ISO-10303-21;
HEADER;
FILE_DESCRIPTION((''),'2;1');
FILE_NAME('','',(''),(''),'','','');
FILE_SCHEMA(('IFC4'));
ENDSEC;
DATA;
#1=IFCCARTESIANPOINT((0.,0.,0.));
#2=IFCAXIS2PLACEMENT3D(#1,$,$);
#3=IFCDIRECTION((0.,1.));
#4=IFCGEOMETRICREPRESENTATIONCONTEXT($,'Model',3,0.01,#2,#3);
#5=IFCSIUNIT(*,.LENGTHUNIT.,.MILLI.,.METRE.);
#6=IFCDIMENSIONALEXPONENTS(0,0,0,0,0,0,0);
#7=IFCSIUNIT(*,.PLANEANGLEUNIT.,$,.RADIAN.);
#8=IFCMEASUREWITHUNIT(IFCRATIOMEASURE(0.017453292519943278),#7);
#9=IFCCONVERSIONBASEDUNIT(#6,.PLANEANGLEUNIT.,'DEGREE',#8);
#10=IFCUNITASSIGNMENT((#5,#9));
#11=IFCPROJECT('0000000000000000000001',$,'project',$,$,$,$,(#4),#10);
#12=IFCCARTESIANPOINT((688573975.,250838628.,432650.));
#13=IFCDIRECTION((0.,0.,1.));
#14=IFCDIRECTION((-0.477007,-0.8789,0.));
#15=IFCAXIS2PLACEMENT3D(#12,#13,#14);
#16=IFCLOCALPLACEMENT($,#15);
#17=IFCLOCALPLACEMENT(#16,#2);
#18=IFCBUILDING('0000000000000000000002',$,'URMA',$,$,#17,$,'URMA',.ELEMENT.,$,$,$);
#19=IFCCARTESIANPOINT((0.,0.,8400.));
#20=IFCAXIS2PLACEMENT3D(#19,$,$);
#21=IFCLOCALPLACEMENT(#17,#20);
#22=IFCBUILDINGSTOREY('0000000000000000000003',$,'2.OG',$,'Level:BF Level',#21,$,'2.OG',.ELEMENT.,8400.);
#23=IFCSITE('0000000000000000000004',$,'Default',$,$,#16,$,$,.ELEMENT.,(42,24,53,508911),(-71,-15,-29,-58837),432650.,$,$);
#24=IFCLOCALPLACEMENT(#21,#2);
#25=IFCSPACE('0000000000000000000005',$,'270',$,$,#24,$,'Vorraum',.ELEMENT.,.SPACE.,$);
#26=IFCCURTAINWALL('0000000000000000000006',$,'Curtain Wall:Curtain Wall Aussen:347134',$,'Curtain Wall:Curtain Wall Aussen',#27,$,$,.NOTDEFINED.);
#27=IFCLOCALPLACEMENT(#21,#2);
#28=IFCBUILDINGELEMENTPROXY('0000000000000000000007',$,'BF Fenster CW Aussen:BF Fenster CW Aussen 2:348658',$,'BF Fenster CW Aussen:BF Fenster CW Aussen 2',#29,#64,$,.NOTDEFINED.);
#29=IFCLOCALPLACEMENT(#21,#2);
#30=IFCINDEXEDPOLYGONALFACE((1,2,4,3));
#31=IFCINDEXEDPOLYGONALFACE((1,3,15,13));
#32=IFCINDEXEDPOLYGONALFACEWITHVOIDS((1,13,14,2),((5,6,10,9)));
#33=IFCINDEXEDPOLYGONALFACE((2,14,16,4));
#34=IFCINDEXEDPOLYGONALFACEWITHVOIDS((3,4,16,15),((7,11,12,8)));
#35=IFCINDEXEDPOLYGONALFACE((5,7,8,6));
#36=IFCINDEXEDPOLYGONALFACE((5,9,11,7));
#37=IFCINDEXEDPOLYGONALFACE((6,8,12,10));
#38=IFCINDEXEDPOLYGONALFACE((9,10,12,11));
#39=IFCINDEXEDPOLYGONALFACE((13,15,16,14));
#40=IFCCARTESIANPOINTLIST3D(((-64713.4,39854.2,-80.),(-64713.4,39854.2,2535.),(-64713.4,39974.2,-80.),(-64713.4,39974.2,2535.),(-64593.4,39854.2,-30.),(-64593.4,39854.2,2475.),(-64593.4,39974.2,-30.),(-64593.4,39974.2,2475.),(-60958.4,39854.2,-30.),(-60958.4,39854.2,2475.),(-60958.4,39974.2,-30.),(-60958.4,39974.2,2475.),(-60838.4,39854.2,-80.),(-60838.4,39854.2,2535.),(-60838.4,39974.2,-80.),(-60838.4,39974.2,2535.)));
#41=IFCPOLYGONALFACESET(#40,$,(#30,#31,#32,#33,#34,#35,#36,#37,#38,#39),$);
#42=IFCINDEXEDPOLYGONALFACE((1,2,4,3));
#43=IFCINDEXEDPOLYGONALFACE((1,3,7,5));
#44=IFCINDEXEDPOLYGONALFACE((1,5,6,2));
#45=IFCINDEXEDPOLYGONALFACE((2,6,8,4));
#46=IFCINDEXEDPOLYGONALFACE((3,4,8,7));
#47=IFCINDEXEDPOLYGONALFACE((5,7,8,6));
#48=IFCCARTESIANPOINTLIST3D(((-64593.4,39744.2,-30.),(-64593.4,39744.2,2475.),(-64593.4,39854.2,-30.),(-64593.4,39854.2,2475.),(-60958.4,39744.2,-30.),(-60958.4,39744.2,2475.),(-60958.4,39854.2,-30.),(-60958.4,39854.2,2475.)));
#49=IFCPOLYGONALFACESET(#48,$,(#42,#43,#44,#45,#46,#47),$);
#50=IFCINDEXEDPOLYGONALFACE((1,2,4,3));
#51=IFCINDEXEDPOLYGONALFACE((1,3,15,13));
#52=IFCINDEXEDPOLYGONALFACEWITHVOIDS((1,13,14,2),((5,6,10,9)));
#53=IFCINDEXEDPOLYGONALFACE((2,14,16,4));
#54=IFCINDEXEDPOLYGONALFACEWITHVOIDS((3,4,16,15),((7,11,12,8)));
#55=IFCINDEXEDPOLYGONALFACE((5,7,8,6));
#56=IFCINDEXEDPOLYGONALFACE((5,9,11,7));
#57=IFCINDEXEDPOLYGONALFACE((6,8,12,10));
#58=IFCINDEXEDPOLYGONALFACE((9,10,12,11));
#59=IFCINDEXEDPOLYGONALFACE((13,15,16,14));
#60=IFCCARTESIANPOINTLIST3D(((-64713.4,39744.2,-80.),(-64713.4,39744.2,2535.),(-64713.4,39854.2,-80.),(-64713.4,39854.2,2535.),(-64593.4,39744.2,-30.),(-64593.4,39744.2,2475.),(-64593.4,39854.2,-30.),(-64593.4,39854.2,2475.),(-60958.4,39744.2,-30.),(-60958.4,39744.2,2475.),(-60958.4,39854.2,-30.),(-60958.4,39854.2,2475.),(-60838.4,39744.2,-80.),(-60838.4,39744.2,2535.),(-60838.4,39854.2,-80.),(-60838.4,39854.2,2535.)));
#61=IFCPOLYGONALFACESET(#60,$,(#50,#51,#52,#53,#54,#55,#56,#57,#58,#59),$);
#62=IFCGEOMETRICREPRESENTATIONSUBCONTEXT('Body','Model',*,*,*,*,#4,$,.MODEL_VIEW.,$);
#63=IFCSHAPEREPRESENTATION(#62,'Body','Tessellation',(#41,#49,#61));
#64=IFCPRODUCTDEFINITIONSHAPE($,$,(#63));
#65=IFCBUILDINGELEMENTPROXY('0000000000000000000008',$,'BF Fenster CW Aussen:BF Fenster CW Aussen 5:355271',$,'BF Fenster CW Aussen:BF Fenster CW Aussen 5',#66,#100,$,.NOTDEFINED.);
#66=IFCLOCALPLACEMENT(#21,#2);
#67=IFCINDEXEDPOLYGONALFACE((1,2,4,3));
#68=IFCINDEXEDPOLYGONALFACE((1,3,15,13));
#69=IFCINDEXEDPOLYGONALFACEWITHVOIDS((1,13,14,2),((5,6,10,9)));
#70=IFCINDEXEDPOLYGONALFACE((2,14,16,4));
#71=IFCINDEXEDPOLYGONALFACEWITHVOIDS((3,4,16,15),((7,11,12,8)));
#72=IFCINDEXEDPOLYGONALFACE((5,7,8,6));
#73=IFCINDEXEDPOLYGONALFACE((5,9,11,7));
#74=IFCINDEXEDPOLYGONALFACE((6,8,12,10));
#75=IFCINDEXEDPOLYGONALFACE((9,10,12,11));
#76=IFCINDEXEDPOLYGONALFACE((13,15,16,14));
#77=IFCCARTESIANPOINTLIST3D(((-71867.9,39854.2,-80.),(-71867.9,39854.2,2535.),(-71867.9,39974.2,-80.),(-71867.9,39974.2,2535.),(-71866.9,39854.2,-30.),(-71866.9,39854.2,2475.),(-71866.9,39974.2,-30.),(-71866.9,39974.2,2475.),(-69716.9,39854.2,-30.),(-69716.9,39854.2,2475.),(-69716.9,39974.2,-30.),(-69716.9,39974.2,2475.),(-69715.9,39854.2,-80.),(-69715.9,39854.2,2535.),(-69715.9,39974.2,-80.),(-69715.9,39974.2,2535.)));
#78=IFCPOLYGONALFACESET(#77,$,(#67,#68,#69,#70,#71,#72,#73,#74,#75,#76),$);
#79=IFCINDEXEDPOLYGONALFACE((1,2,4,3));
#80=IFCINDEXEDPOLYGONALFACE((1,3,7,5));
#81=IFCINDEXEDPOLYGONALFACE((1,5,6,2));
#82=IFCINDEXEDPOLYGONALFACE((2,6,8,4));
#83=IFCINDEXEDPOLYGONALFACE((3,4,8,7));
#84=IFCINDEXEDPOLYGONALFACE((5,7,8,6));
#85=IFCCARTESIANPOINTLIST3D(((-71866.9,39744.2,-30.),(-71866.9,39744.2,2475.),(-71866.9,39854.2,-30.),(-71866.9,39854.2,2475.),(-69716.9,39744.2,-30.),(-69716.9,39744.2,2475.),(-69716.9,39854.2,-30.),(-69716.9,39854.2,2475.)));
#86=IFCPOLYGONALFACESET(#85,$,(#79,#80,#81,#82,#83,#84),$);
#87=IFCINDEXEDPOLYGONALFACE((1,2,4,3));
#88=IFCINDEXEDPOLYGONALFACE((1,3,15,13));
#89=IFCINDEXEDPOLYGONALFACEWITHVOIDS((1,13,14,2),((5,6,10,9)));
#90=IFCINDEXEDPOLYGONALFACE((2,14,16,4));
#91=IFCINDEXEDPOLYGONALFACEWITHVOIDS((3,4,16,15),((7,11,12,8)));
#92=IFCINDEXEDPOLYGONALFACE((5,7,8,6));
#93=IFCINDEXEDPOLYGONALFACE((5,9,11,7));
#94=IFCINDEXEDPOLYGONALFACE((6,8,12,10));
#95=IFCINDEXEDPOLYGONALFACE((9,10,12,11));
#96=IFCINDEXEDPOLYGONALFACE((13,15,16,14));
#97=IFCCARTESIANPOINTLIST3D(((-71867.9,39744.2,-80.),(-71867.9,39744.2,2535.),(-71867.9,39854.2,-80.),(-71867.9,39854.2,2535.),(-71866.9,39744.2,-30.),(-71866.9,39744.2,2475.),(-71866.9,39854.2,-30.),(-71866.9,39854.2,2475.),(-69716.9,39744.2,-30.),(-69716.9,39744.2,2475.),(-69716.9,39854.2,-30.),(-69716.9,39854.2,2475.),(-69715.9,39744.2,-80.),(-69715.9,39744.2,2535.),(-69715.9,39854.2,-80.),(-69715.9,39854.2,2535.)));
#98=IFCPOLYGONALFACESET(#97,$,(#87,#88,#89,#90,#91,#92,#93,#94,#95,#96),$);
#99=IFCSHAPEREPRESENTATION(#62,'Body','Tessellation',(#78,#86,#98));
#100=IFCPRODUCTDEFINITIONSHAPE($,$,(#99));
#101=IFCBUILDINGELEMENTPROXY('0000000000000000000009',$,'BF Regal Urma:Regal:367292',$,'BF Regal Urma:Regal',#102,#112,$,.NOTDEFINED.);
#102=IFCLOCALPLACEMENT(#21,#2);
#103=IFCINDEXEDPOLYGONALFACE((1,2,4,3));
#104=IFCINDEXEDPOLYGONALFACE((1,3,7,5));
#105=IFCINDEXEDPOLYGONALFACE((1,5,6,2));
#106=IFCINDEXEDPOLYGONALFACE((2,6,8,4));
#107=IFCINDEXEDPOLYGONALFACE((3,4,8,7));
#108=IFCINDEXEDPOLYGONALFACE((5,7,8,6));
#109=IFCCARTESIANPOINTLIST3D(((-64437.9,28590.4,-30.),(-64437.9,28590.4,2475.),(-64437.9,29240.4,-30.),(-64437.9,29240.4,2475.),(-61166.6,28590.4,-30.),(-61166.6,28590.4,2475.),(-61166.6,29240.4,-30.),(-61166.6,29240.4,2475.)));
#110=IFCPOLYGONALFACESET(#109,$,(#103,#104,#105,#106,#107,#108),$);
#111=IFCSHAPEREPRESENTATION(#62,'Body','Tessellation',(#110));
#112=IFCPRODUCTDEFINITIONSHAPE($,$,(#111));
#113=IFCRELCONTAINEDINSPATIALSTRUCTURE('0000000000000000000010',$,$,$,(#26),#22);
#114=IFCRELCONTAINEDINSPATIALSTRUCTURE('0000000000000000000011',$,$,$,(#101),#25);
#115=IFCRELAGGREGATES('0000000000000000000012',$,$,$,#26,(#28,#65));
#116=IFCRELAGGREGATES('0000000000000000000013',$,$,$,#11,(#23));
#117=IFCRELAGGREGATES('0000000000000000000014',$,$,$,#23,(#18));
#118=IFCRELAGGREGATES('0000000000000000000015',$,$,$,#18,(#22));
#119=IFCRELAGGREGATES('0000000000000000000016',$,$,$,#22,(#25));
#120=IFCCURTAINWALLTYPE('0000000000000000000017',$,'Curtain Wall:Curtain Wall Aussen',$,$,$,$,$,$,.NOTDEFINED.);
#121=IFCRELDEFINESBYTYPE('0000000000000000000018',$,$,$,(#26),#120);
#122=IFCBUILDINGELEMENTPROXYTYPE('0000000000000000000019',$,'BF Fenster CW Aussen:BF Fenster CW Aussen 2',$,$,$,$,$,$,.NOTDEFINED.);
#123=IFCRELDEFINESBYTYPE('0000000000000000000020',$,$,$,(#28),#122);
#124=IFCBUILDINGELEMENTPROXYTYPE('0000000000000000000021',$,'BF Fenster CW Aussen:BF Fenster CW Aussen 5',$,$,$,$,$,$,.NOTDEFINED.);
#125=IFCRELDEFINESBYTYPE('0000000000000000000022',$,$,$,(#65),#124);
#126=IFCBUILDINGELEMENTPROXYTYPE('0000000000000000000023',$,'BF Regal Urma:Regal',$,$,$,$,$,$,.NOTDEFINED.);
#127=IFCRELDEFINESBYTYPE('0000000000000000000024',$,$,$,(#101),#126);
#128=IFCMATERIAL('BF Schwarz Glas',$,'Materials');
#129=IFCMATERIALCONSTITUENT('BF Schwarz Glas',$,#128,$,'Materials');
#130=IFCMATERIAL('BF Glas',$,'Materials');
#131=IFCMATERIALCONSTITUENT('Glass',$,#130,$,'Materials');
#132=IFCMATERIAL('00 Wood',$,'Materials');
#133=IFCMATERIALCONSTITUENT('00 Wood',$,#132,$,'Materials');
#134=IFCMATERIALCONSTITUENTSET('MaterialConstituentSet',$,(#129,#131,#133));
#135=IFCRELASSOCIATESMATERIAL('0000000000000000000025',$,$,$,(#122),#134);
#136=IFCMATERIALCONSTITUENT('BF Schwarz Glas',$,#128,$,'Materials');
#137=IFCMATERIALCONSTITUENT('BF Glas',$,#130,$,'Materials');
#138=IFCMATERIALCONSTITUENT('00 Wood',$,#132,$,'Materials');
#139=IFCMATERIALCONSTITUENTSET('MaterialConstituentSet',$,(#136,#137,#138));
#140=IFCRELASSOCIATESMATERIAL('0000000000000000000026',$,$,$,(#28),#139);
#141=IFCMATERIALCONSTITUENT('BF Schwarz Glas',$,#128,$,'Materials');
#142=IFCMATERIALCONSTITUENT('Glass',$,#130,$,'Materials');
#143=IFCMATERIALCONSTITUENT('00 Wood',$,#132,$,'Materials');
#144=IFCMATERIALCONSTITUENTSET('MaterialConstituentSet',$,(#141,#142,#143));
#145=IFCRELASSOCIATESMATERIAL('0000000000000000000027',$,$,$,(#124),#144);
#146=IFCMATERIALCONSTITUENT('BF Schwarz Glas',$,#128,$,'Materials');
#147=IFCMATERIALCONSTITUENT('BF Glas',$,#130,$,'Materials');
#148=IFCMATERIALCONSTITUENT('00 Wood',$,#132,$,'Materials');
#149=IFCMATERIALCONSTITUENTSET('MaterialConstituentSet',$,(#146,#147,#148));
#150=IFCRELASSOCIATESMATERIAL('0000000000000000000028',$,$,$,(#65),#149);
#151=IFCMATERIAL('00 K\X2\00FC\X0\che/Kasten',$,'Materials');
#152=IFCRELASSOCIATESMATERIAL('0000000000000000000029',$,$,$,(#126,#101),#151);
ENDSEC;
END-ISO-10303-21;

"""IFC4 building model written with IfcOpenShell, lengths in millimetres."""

from ifc_helpers import new_model, entity, si_unit, converted_unit, direction, frame, origin, place, context, subcontext, project, spatial, indexed_curve, outline, extrude, source, transform, mapped, material, constituent, constituent_set, type_object, type_shapes, element, aggregate, save


model = new_model("IFC4")

# Units and contexts
model_context = context("Model", 3, precision=0.01, world=origin(), true_north=direction((0.0, 1.0)))
body_context = subcontext(model_context, "Body", "Model", "MODEL_VIEW")
ifc_project = project(units=[si_unit("LENGTHUNIT", "METRE", prefix="MILLI"), converted_unit("PLANEANGLEUNIT", "DEGREE", entity("IfcRatioMeasure", 0.017453292519943278), si_unit("PLANEANGLEUNIT", "RADIAN"), dimensions=[0, 0, 0, 0, 0, 0, 0])], contexts=[model_context])

# Site, building, storey
site_placement = place(None, frame((688573975.0, 250838628.0, 432650.0), z_axis=(0.0, 0.0, 1.0), x_axis=(-0.477007, -0.8789, 0.0)))
site = spatial("IfcSite", under=ifc_project, at=site_placement, Name="Default", CompositionType="ELEMENT", RefLatitude=(42, 24, 53, 508911), RefLongitude=(-71, -15, -29, -58837), RefElevation=432650.0)
building_placement = place(site_placement, origin())
building = spatial("IfcBuilding", under=site, at=building_placement, Name="URMA", LongName="URMA", CompositionType="ELEMENT")
storey_placement = place(building_placement, frame((0.0, 0.0, 8400.0)))
storey = spatial("IfcBuildingStorey", under=building, at=storey_placement, Name="2.OG", ObjectType="Level:BF Level", LongName="2.OG", CompositionType="ELEMENT", Elevation=8400.0)

# Shared definitions
curtain_wall_type = type_object("IfcCurtainWallType", Name="Curtain Wall:Curtain Wall Aussen", PredefinedType="NOTDEFINED")

# Curtain wall, building element proxies
curtain_wall_1_placement = place(storey_placement, frame((0.0, 0.0, -8400.0)))
curtain_wall_1 = element("IfcCurtainWall", 1, at=curtain_wall_1_placement, inside=storey, type_object=curtain_wall_type, Name="Curtain Wall:Curtain Wall Aussen:347134", ObjectType="Curtain Wall:Curtain Wall Aussen", PredefinedType="NOTDEFINED")
ifc_material_1 = material(Name="BF Schwarz Glas", Category="Materials")
ifc_material_2 = material(Name="BF Glas", Category="Materials")
ifc_material_3 = material(Name="00 Wood", Category="Materials")
ifc_constituent_1 = constituent(ifc_material_1, Name="BF Schwarz Glas", Category="Materials")
ifc_constituent_2 = constituent(ifc_material_2, Name="BF Glas", Category="Materials")
ifc_constituent_3 = constituent(ifc_material_3, Name="00 Wood", Category="Materials")
ifc_constituent_set_1 = constituent_set(constituents=[ifc_constituent_1, ifc_constituent_2, ifc_constituent_3], Name="MaterialConstituentSet")
ifc_constituent_4 = constituent(ifc_material_1, Name="BF Schwarz Glas", Category="Materials")
ifc_constituent_5 = constituent(ifc_material_2, Name="Glass", Category="Materials")
ifc_constituent_6 = constituent(ifc_material_3, Name="00 Wood", Category="Materials")
ifc_constituent_set_2 = constituent_set(constituents=[ifc_constituent_4, ifc_constituent_5, ifc_constituent_6], Name="MaterialConstituentSet")
building_element_proxy_type_1 = type_object("IfcBuildingElementProxyType", Name="BF Fenster CW Aussen:BF Fenster CW Aussen 2", PredefinedType="NOTDEFINED", material=ifc_constituent_set_2)
shared_shape_1 = source(origin(), body_context, "Body", "SweptSolid", [
    extrude(outline(indexed_curve([(-1937.5, -1307.5), (1937.5, -1307.5), (1937.5, 1307.5), (-1937.5, 1307.5), (-1937.5, -1307.5)], self_intersect=False), holes=[indexed_curve([(-1817.5, -1247.5), (-1817.5, 1257.5), (1817.5, 1257.5), (1817.5, -1247.5), (-1817.5, -1247.5)], self_intersect=False)]), frame((0.0, -120.0, 1307.5), z_axis=(0.0, 1.0, 0.0), x_axis=(1.0, 0.0, 0.0)), (0.0, 0.0, 1.0), 120.0),
    extrude(outline(indexed_curve([(-55.0, -1817.5), (55.0, -1817.5), (55.0, 1817.5), (-55.0, 1817.5), (-55.0, -1817.5)], self_intersect=False)), frame((0.0, 55.0, 50.0), z_axis=(0.0, 0.0, 1.0), x_axis=(0.0, 1.0, 0.0)), (0.0, 0.0, 1.0), 2505.0),
    extrude(outline(indexed_curve([(-1937.5, -1307.5), (1937.5, -1307.5), (1937.5, 1307.5), (-1937.5, 1307.5), (-1937.5, -1307.5)], self_intersect=False), holes=[indexed_curve([(-1817.5, -1247.5), (-1817.5, 1257.5), (1817.5, 1257.5), (1817.5, -1247.5), (-1817.5, -1247.5)], self_intersect=False)]), frame((0.0, 0.0, 1307.5), z_axis=(0.0, 1.0, 0.0), x_axis=(1.0, 0.0, 0.0)), (0.0, 0.0, 1.0), 110.0),
])
type_shapes(building_element_proxy_type_1, [shared_shape_1])
proxy_1_placement = place(storey_placement, frame((-62775.9, 39854.2, -80.0), z_axis=(0.0, 0.0, 1.0), x_axis=(-1.0, 0.0, 0.0)))
proxy_1 = element("IfcBuildingElementProxy", 2, at=proxy_1_placement, type_object=building_element_proxy_type_1, material=ifc_constituent_set_1, Name="BF Fenster CW Aussen:BF Fenster CW Aussen 2:348658", ObjectType="BF Fenster CW Aussen:BF Fenster CW Aussen 2", PredefinedType="NOTDEFINED", context=body_context, shape_type="MappedRepresentation", body=[
    mapped(shared_shape_1, transform((0.0, 0.0, 0.0), scale=1.0)),
])
ifc_constituent_7 = constituent(ifc_material_1, Name="BF Schwarz Glas", Category="Materials")
ifc_constituent_8 = constituent(ifc_material_2, Name="BF Glas", Category="Materials")
ifc_constituent_9 = constituent(ifc_material_3, Name="00 Wood", Category="Materials")
ifc_constituent_set_3 = constituent_set(constituents=[ifc_constituent_7, ifc_constituent_8, ifc_constituent_9], Name="MaterialConstituentSet")
ifc_constituent_10 = constituent(ifc_material_1, Name="BF Schwarz Glas", Category="Materials")
ifc_constituent_11 = constituent(ifc_material_2, Name="Glass", Category="Materials")
ifc_constituent_12 = constituent(ifc_material_3, Name="00 Wood", Category="Materials")
ifc_constituent_set_4 = constituent_set(constituents=[ifc_constituent_10, ifc_constituent_11, ifc_constituent_12], Name="MaterialConstituentSet")
building_element_proxy_type_2 = type_object("IfcBuildingElementProxyType", Name="BF Fenster CW Aussen:BF Fenster CW Aussen 5", PredefinedType="NOTDEFINED", material=ifc_constituent_set_4)
shared_shape_2 = source(origin(), body_context, "Body", "SweptSolid", [
    extrude(outline(indexed_curve([(-1076.0, -1307.5), (1076.0, -1307.5), (1076.0, 1307.5), (-1076.0, 1307.5), (-1076.0, -1307.5)], self_intersect=False), holes=[indexed_curve([(-1075.0, -1247.5), (-1075.0, 1257.5), (1075.0, 1257.5), (1075.0, -1247.5), (-1075.0, -1247.5)], self_intersect=False)]), frame((0.0, -120.0, 1307.5), z_axis=(0.0, 1.0, 0.0), x_axis=(1.0, 0.0, 0.0)), (0.0, 0.0, 1.0), 120.0),
    extrude(outline(indexed_curve([(-55.0, -1075.0), (55.0, -1075.0), (55.0, 1075.0), (-55.0, 1075.0), (-55.0, -1075.0)], self_intersect=False)), frame((0.0, 55.0, 50.0), z_axis=(0.0, 0.0, 1.0), x_axis=(0.0, 1.0, 0.0)), (0.0, 0.0, 1.0), 2505.0),
    extrude(outline(indexed_curve([(-1076.0, -1307.5), (1076.0, -1307.5), (1076.0, 1307.5), (-1076.0, 1307.5), (-1076.0, -1307.5)], self_intersect=False), holes=[indexed_curve([(-1075.0, -1247.5), (-1075.0, 1257.5), (1075.0, 1257.5), (1075.0, -1247.5), (-1075.0, -1247.5)], self_intersect=False)]), frame((0.0, 0.0, 1307.5), z_axis=(0.0, 1.0, 0.0), x_axis=(1.0, 0.0, 0.0)), (0.0, 0.0, 1.0), 110.0),
])
type_shapes(building_element_proxy_type_2, [shared_shape_2])
proxy_2_placement = place(storey_placement, frame((-70791.9, 39854.2, -80.0), z_axis=(0.0, 0.0, 1.0), x_axis=(-1.0, 0.0, 0.0)))
proxy_2 = element("IfcBuildingElementProxy", 3, at=proxy_2_placement, type_object=building_element_proxy_type_2, material=ifc_constituent_set_3, Name="BF Fenster CW Aussen:BF Fenster CW Aussen 5:355271", ObjectType="BF Fenster CW Aussen:BF Fenster CW Aussen 5", PredefinedType="NOTDEFINED", context=body_context, shape_type="MappedRepresentation", body=[
    mapped(shared_shape_2, transform((0.0, 0.0, 0.0), scale=1.0)),
])
aggregate(curtain_wall_1, [proxy_1, proxy_2])

# Shared definitions
space_1_placement = place(storey_placement, origin())
space_1 = spatial("IfcSpace", under=storey, at=space_1_placement, Name="270", LongName="Vorraum", CompositionType="ELEMENT", PredefinedType="SPACE")

# Building element proxy
ifc_material_4 = material(Name="00 Küche/Kasten", Category="Materials")
building_element_proxy_type_3 = type_object("IfcBuildingElementProxyType", Name="BF Regal Urma:Regal", PredefinedType="NOTDEFINED", material=ifc_material_4)
shared_shape_3 = source(origin(), body_context, "Body", "SweptSolid", [
    extrude(outline(indexed_curve([(-325.0, -1635.7), (325.0, -1635.7), (325.0, 1635.7), (-325.0, 1635.7), (-325.0, -1635.7)], self_intersect=False)), frame((0.0, 0.0, 0.0), z_axis=(0.0, 0.0, 1.0), x_axis=(0.0, 1.0, 0.0)), (0.0, 0.0, 1.0), 2505.0),
])
type_shapes(building_element_proxy_type_3, [shared_shape_3])
proxy_3_placement = place(space_1_placement, frame((-62802.2, 28915.4, -30.0)))
element("IfcBuildingElementProxy", 4, at=proxy_3_placement, inside=space_1, type_object=building_element_proxy_type_3, material=ifc_material_4, Name="BF Regal Urma:Regal:367292", ObjectType="BF Regal Urma:Regal", PredefinedType="NOTDEFINED", context=body_context, shape_type="MappedRepresentation", body=[
    mapped(shared_shape_3, transform((0.0, 0.0, 0.0), scale=1.0)),
])

save(model, "model.ifc")
